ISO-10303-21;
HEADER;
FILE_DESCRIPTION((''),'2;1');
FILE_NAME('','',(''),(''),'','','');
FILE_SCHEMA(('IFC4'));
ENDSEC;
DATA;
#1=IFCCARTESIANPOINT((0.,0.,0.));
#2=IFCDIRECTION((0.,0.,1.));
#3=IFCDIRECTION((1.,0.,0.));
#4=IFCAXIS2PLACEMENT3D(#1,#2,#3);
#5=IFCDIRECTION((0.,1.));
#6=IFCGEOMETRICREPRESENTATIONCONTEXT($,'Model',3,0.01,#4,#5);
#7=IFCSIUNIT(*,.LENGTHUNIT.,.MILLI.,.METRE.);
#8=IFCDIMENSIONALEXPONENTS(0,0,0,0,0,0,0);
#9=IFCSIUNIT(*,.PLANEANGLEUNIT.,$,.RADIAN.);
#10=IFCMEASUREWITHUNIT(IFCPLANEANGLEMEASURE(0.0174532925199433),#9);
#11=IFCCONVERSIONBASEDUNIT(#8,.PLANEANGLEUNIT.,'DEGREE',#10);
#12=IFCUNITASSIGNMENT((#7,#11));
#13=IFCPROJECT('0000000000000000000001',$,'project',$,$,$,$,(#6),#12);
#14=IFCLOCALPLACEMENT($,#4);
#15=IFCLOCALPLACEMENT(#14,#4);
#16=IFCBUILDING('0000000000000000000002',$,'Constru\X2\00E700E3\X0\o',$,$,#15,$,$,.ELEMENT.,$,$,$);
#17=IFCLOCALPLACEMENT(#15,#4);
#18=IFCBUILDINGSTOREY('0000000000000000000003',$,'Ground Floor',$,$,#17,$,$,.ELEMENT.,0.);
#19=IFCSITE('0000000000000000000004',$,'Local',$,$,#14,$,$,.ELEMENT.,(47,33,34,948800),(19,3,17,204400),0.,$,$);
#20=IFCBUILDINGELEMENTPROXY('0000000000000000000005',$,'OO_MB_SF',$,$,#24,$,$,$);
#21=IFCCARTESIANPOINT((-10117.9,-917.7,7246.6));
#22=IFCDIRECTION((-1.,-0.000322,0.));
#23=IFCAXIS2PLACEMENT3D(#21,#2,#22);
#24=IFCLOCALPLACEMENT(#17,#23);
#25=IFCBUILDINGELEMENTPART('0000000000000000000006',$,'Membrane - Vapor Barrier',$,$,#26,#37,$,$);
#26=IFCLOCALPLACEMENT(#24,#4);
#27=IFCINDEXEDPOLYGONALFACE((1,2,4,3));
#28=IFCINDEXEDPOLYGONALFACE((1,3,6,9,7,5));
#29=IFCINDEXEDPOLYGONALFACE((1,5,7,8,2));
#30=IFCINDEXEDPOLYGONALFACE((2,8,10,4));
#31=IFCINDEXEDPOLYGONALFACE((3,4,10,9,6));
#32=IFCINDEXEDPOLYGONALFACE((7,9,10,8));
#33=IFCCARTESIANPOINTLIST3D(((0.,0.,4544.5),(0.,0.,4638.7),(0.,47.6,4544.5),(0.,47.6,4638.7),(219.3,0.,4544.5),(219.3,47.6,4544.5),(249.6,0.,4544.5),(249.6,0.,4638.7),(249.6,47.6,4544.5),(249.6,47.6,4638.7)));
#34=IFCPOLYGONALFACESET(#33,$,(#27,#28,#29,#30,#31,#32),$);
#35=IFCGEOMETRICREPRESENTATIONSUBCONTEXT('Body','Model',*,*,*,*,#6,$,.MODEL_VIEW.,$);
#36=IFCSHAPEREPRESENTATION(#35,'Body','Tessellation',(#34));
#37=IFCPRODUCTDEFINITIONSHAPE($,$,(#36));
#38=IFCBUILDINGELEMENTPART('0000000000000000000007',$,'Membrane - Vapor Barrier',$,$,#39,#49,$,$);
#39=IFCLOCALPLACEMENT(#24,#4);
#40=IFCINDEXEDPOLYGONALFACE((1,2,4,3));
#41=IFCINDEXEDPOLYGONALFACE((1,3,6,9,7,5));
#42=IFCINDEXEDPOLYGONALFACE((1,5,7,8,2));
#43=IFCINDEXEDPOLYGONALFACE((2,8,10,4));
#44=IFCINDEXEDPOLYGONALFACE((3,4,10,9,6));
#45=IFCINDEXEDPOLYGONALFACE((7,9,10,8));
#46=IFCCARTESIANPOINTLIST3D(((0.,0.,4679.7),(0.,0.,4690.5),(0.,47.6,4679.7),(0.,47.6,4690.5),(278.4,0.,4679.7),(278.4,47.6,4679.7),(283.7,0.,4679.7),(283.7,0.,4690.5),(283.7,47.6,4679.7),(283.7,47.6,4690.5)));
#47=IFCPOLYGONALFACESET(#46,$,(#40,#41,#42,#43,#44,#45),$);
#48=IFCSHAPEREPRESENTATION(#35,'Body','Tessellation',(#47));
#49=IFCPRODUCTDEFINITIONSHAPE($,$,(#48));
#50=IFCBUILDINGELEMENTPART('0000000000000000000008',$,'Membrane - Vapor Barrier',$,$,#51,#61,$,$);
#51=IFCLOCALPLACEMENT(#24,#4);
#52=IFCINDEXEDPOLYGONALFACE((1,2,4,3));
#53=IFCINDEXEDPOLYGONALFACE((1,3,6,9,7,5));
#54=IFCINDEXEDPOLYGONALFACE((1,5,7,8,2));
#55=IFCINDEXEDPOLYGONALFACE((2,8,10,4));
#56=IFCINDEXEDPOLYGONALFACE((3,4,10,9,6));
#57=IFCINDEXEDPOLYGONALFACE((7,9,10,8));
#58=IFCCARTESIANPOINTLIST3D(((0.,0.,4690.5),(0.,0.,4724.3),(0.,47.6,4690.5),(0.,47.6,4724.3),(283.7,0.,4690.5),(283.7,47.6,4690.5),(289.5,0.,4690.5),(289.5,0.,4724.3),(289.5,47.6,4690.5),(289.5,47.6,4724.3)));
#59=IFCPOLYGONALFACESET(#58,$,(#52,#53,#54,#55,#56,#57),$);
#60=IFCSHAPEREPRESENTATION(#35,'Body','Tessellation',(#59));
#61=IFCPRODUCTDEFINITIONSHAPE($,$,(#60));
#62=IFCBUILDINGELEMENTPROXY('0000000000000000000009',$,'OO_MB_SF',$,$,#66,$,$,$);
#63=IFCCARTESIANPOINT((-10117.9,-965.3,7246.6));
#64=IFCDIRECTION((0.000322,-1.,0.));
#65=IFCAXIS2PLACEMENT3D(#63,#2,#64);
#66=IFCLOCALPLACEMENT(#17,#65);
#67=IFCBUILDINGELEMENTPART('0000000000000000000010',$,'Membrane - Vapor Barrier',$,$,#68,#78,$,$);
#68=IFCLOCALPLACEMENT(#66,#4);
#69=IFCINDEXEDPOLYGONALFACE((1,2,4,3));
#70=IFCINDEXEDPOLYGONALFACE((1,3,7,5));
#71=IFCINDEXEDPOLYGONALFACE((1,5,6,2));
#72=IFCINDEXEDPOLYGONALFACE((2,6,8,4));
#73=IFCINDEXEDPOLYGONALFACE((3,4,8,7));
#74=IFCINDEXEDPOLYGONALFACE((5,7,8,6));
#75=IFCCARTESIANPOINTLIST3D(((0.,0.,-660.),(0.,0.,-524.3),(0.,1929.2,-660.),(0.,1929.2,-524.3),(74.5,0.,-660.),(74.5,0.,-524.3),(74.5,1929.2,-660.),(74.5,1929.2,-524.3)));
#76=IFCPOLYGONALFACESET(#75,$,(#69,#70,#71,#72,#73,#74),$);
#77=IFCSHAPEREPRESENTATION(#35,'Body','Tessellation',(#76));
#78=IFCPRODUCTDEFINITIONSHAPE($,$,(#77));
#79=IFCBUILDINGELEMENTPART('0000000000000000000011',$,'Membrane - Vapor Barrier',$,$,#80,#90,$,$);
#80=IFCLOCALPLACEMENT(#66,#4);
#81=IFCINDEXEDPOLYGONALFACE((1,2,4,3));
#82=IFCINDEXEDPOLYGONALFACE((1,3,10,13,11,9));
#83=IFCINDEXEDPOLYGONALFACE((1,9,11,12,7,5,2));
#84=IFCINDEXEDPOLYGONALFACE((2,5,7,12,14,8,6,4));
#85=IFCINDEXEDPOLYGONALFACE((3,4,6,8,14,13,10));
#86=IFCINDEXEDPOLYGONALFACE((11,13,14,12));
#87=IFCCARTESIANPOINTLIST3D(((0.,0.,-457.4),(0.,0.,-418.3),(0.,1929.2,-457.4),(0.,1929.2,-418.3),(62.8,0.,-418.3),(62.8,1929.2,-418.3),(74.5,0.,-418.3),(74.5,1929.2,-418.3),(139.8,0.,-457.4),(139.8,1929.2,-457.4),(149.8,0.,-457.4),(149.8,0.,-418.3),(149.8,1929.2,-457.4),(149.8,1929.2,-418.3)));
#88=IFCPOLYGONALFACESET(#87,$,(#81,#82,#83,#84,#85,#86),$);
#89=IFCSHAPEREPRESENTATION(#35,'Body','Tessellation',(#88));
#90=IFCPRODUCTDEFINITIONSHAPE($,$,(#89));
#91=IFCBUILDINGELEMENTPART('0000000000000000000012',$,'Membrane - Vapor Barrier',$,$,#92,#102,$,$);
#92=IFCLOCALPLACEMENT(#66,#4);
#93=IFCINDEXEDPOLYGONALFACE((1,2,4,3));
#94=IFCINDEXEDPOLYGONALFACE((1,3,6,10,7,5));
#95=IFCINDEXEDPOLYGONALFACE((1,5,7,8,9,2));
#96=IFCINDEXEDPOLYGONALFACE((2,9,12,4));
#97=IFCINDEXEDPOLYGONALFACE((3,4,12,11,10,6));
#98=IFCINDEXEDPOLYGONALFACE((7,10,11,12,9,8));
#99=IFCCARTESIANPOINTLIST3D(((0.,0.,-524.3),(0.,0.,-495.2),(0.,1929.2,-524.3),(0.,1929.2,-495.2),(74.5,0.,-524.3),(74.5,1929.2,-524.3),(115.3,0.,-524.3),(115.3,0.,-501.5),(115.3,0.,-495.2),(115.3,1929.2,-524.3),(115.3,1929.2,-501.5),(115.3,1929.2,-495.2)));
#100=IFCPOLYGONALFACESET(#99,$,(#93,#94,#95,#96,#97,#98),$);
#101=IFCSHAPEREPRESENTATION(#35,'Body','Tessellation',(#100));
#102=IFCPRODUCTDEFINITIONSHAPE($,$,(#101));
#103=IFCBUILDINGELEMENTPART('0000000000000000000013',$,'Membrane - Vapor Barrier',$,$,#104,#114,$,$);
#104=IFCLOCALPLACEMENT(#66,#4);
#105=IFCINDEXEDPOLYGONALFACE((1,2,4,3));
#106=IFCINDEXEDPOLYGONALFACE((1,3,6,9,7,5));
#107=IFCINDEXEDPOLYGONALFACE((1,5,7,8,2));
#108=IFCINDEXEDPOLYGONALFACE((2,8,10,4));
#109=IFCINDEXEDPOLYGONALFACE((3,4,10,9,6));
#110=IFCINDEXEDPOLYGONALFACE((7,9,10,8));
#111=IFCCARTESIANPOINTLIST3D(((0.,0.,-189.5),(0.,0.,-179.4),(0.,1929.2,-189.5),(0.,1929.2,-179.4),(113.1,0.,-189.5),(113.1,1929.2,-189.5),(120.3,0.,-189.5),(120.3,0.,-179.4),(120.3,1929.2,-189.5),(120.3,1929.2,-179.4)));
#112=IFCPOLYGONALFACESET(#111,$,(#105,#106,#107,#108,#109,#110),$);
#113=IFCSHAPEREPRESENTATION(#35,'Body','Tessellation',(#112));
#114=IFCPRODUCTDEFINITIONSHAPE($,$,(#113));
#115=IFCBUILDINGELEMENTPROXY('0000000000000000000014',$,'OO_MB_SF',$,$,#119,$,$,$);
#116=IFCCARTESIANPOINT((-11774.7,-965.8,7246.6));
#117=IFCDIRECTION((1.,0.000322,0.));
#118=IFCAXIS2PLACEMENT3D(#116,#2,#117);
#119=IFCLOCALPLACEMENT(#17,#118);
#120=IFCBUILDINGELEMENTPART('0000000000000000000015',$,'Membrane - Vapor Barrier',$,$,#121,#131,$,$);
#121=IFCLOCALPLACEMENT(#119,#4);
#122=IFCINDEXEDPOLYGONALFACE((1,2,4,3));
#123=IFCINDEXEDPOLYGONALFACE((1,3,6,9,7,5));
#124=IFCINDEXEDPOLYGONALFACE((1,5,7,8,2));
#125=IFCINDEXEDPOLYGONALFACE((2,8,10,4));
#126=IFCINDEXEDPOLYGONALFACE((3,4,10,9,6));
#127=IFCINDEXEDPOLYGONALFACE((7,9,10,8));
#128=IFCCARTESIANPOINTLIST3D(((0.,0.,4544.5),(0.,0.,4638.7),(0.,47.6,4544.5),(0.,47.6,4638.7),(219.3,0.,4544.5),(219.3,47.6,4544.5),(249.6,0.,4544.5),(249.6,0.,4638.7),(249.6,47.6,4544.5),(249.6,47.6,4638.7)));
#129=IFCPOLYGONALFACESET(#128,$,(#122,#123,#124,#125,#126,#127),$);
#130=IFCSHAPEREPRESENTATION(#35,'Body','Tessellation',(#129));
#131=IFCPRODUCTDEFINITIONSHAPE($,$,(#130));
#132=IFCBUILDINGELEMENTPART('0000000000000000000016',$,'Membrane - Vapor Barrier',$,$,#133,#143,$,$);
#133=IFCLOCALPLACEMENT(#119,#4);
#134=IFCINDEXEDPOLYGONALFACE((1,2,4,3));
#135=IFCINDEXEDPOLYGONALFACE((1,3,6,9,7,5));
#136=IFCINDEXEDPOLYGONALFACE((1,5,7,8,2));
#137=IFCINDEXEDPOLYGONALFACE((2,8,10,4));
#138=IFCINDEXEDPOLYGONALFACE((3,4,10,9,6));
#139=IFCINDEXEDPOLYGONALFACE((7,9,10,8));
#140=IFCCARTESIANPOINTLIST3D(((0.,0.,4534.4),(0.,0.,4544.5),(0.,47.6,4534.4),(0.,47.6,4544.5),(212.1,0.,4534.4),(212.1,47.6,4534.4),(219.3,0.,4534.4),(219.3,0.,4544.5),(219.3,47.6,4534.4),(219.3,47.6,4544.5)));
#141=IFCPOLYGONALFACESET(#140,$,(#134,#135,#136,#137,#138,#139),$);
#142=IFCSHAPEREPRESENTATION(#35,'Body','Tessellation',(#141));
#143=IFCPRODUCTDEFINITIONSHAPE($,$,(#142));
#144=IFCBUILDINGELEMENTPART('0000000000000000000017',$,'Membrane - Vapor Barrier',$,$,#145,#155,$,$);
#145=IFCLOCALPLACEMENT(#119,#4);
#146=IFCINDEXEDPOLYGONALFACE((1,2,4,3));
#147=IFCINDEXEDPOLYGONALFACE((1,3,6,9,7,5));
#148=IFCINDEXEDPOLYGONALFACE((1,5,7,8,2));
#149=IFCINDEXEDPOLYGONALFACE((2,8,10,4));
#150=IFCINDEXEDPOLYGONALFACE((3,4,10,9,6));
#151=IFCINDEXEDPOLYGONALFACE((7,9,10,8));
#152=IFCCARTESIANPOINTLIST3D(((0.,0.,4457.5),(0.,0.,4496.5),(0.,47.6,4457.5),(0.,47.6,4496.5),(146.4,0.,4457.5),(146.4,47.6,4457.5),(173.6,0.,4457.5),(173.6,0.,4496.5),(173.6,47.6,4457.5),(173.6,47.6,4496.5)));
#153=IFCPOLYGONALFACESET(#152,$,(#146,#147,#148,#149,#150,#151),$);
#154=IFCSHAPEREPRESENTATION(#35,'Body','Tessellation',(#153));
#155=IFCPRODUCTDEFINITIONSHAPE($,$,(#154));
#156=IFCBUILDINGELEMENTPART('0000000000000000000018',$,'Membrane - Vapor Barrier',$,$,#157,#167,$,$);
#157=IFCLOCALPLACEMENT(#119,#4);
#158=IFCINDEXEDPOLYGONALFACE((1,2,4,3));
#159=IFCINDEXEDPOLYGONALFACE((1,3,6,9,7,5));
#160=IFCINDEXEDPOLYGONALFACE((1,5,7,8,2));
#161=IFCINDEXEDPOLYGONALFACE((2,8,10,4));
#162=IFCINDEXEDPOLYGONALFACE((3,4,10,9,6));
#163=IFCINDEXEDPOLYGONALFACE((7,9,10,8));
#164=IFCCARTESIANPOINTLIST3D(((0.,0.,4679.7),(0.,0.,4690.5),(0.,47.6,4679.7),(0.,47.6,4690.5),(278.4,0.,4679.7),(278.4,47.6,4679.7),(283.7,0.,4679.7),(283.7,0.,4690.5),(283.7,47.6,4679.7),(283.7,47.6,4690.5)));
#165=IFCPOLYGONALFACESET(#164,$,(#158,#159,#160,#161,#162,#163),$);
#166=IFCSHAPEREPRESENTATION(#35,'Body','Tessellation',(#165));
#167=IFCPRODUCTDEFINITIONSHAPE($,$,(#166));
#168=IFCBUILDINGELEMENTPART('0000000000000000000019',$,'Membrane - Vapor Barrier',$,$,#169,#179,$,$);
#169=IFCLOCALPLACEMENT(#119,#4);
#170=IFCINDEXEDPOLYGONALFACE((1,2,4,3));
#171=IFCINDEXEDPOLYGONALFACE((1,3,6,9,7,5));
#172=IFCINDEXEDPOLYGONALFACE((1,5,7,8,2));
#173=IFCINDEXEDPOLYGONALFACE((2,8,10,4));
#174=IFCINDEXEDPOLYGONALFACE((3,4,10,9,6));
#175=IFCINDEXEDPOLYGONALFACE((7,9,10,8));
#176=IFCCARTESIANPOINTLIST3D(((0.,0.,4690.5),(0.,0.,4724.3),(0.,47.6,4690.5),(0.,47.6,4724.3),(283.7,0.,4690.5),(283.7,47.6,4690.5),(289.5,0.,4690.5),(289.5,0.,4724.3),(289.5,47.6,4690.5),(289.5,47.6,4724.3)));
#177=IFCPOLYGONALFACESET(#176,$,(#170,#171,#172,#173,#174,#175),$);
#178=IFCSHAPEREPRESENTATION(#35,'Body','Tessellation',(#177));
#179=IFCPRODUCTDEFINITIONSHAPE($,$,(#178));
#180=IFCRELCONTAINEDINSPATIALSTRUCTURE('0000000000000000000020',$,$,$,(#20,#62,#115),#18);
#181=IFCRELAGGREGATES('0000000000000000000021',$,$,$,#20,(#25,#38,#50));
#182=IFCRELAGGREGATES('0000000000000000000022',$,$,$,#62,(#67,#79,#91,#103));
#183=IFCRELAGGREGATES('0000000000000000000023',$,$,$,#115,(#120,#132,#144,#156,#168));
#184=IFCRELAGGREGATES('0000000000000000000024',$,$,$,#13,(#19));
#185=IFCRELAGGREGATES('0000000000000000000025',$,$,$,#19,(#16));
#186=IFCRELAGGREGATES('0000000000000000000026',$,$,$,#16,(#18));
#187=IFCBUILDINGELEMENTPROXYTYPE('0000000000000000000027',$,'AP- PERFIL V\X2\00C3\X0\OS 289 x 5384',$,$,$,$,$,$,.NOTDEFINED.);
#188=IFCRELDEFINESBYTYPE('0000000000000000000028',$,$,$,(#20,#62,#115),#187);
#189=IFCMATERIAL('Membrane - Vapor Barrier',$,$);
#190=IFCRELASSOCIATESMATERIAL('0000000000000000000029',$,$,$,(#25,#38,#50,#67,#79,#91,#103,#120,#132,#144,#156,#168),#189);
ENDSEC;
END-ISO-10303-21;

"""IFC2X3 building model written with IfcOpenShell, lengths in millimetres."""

from ifc_helpers import new_model, entity, si_unit, converted_unit, direction, frame, origin_with_axes, place, context, subcontext, project, spatial, polyline, outline, extrude, material, type_object, element, aggregate, save


model = new_model("IFC2X3")

# Units and contexts
model_context = context("Model", 3, precision=0.01, world=origin_with_axes(), true_north=direction((0.0, 1.0)))
body_context = subcontext(model_context, "Body", "Model", "MODEL_VIEW")
ifc_project = project(units=[si_unit("LENGTHUNIT", "METRE", prefix="MILLI"), converted_unit("PLANEANGLEUNIT", "DEGREE", entity("IfcPlaneAngleMeasure", 0.0174532925199433), si_unit("PLANEANGLEUNIT", "RADIAN"), dimensions=[0, 0, 0, 0, 0, 0, 0])], contexts=[model_context])

# Site, building, storey
site_placement = place(None, origin_with_axes())
site = spatial("IfcSite", under=ifc_project, at=site_placement, Name="Local", CompositionType="ELEMENT", RefLatitude=(47, 33, 34, 948800), RefLongitude=(19, 3, 17, 204400), RefElevation=0.0)
building_placement = place(site_placement, origin_with_axes())
building = spatial("IfcBuilding", under=site, at=building_placement, Name="Construção", CompositionType="ELEMENT")
storey_placement = place(building_placement, origin_with_axes())
storey = spatial("IfcBuildingStorey", under=building, at=storey_placement, Name="Ground Floor", CompositionType="ELEMENT", Elevation=0.0)

# Shared definitions
ifc_material = material(Name="Membrane - Vapor Barrier")

# Building element proxies, building element parts
building_element_proxy_type = type_object("IfcBuildingElementProxyType", Name="AP- PERFIL VÃOS 289 x 5384", PredefinedType="NOTDEFINED")
proxy_1_placement = place(storey_placement, frame((-10117.9, -917.7, 7246.6), z_axis=(0.0, 0.0, 1.0), x_axis=(-1.0, -0.000322, 0.0)))
proxy_1 = element("IfcBuildingElementProxy", 1, at=proxy_1_placement, inside=storey, type_object=building_element_proxy_type, Name="OO_MB_SF")
building_element_part_1_placement = place(proxy_1_placement, origin_with_axes())
building_element_part_1 = element("IfcBuildingElementPart", 2, at=building_element_part_1_placement, material=ifc_material, Name="Membrane - Vapor Barrier", context=body_context, shape_type="SweptSolid", body=[
    extrude(outline(polyline([(249.6, 4638.7), (0.0, 4638.7), (0.0, 4544.5), (219.3, 4544.5), (249.6, 4544.5), (249.6, 4638.7)])), frame((0.0, 47.6, 0.0), z_axis=(0.0, -1.0, 0.0), x_axis=(1.0, 0.0, 0.0)), (0.0, 0.0, 1.0), 47.6),
])
building_element_part_2_placement = place(proxy_1_placement, origin_with_axes())
building_element_part_2 = element("IfcBuildingElementPart", 3, at=building_element_part_2_placement, material=ifc_material, Name="Membrane - Vapor Barrier", context=body_context, shape_type="SweptSolid", body=[
    extrude(outline(polyline([(0.0, 4679.7), (278.4, 4679.7), (283.7, 4679.7), (283.7, 4690.5), (0.0, 4690.5), (0.0, 4679.7)])), frame((0.0, 47.6, 0.0), z_axis=(0.0, -1.0, 0.0), x_axis=(1.0, 0.0, 0.0)), (0.0, 0.0, 1.0), 47.6),
])
building_element_part_3_placement = place(proxy_1_placement, origin_with_axes())
building_element_part_3 = element("IfcBuildingElementPart", 4, at=building_element_part_3_placement, material=ifc_material, Name="Membrane - Vapor Barrier", context=body_context, shape_type="SweptSolid", body=[
    extrude(outline(polyline([(0.0, 4690.5), (283.7, 4690.5), (289.5, 4690.5), (289.5, 4724.3), (0.0, 4724.3), (0.0, 4690.5)])), frame((0.0, 47.6, 0.0), z_axis=(0.0, -1.0, 0.0), x_axis=(1.0, 0.0, 0.0)), (0.0, 0.0, 1.0), 47.6),
])
aggregate(proxy_1, [building_element_part_1, building_element_part_2, building_element_part_3])
proxy_2_placement = place(storey_placement, frame((-10117.9, -965.3, 7246.6), z_axis=(0.0, 0.0, 1.0), x_axis=(0.000322, -1.0, 0.0)))
proxy_2 = element("IfcBuildingElementProxy", 5, at=proxy_2_placement, inside=storey, type_object=building_element_proxy_type, Name="OO_MB_SF")
building_element_part_4_placement = place(proxy_2_placement, origin_with_axes())
building_element_part_4 = element("IfcBuildingElementPart", 6, at=building_element_part_4_placement, material=ifc_material, Name="Membrane - Vapor Barrier", context=body_context, shape_type="SweptSolid", body=[
    extrude(outline(polyline([(0.0, -660.0), (74.5, -660.0), (74.5, -524.3), (0.0, -524.3), (0.0, -660.0)])), frame((0.0, 1929.2, 0.0), z_axis=(0.0, -1.0, 0.0), x_axis=(1.0, 0.0, 0.0)), (0.0, 0.0, 1.0), 1929.2),
])
building_element_part_5_placement = place(proxy_2_placement, origin_with_axes())
building_element_part_5 = element("IfcBuildingElementPart", 7, at=building_element_part_5_placement, material=ifc_material, Name="Membrane - Vapor Barrier", context=body_context, shape_type="SweptSolid", body=[
    extrude(outline(polyline([(62.8, -418.3), (0.0, -418.3), (0.0, -457.4), (139.8, -457.4), (149.8, -457.4), (149.8, -418.3), (74.5, -418.3), (62.8, -418.3)])), frame((0.0, 1929.2, 0.0), z_axis=(0.0, -1.0, 0.0), x_axis=(1.0, 0.0, 0.0)), (0.0, 0.0, 1.0), 1929.2),
])
building_element_part_6_placement = place(proxy_2_placement, origin_with_axes())
building_element_part_6 = element("IfcBuildingElementPart", 8, at=building_element_part_6_placement, material=ifc_material, Name="Membrane - Vapor Barrier", context=body_context, shape_type="SweptSolid", body=[
    extrude(outline(polyline([(0.0, -524.3), (74.5, -524.3), (115.3, -524.3), (115.3, -501.5), (115.3, -495.2), (0.0, -495.2), (0.0, -524.3)])), frame((0.0, 1929.2, 0.0), z_axis=(0.0, -1.0, 0.0), x_axis=(1.0, 0.0, 0.0)), (0.0, 0.0, 1.0), 1929.2),
])
building_element_part_7_placement = place(proxy_2_placement, origin_with_axes())
building_element_part_7 = element("IfcBuildingElementPart", 9, at=building_element_part_7_placement, material=ifc_material, Name="Membrane - Vapor Barrier", context=body_context, shape_type="SweptSolid", body=[
    extrude(outline(polyline([(120.3, -179.4), (0.0, -179.4), (0.0, -189.5), (113.1, -189.5), (120.3, -189.5), (120.3, -179.4)])), frame((0.0, 1929.2, 0.0), z_axis=(0.0, -1.0, 0.0), x_axis=(1.0, 0.0, 0.0)), (0.0, 0.0, 1.0), 1929.2),
])
aggregate(proxy_2, [building_element_part_4, building_element_part_5, building_element_part_6, building_element_part_7])
proxy_3_placement = place(storey_placement, frame((-11774.7, -965.8, 7246.6), z_axis=(0.0, 0.0, 1.0), x_axis=(1.0, 0.000322, 0.0)))
proxy_3 = element("IfcBuildingElementProxy", 10, at=proxy_3_placement, inside=storey, type_object=building_element_proxy_type, Name="OO_MB_SF")
building_element_part_8_placement = place(proxy_3_placement, origin_with_axes())
building_element_part_8 = element("IfcBuildingElementPart", 11, at=building_element_part_8_placement, material=ifc_material, Name="Membrane - Vapor Barrier", context=body_context, shape_type="SweptSolid", body=[
    extrude(outline(polyline([(249.6, 4638.7), (0.0, 4638.7), (0.0, 4544.5), (219.3, 4544.5), (249.6, 4544.5), (249.6, 4638.7)])), frame((0.0, 47.6, 0.0), z_axis=(0.0, -1.0, 0.0), x_axis=(1.0, 0.0, 0.0)), (0.0, 0.0, 1.0), 47.6),
])
building_element_part_9_placement = place(proxy_3_placement, origin_with_axes())
building_element_part_9 = element("IfcBuildingElementPart", 12, at=building_element_part_9_placement, material=ifc_material, Name="Membrane - Vapor Barrier", context=body_context, shape_type="SweptSolid", body=[
    extrude(outline(polyline([(0.0, 4534.4), (212.1, 4534.4), (219.3, 4534.4), (219.3, 4544.5), (0.0, 4544.5), (0.0, 4534.4)])), frame((0.0, 47.6, 0.0), z_axis=(0.0, -1.0, 0.0), x_axis=(1.0, 0.0, 0.0)), (0.0, 0.0, 1.0), 47.6),
])
building_element_part_10_placement = place(proxy_3_placement, origin_with_axes())
building_element_part_10 = element("IfcBuildingElementPart", 13, at=building_element_part_10_placement, material=ifc_material, Name="Membrane - Vapor Barrier", context=body_context, shape_type="SweptSolid", body=[
    extrude(outline(polyline([(173.6, 4496.5), (0.0, 4496.5), (0.0, 4457.5), (146.4, 4457.5), (173.6, 4457.5), (173.6, 4496.5)])), frame((0.0, 47.6, 0.0), z_axis=(0.0, -1.0, 0.0), x_axis=(1.0, 0.0, 0.0)), (0.0, 0.0, 1.0), 47.6),
])
building_element_part_11_placement = place(proxy_3_placement, origin_with_axes())
building_element_part_11 = element("IfcBuildingElementPart", 14, at=building_element_part_11_placement, material=ifc_material, Name="Membrane - Vapor Barrier", context=body_context, shape_type="SweptSolid", body=[
    extrude(outline(polyline([(0.0, 4679.7), (278.4, 4679.7), (283.7, 4679.7), (283.7, 4690.5), (0.0, 4690.5), (0.0, 4679.7)])), frame((0.0, 47.6, 0.0), z_axis=(0.0, -1.0, 0.0), x_axis=(1.0, 0.0, 0.0)), (0.0, 0.0, 1.0), 47.6),
])
building_element_part_12_placement = place(proxy_3_placement, origin_with_axes())
building_element_part_12 = element("IfcBuildingElementPart", 15, at=building_element_part_12_placement, material=ifc_material, Name="Membrane - Vapor Barrier", context=body_context, shape_type="SweptSolid", body=[
    extrude(outline(polyline([(0.0, 4690.5), (283.7, 4690.5), (289.5, 4690.5), (289.5, 4724.3), (0.0, 4724.3), (0.0, 4690.5)])), frame((0.0, 47.6, 0.0), z_axis=(0.0, -1.0, 0.0), x_axis=(1.0, 0.0, 0.0)), (0.0, 0.0, 1.0), 47.6),
])
aggregate(proxy_3, [building_element_part_8, building_element_part_9, building_element_part_10, building_element_part_11, building_element_part_12])

save(model, "model.ifc")
